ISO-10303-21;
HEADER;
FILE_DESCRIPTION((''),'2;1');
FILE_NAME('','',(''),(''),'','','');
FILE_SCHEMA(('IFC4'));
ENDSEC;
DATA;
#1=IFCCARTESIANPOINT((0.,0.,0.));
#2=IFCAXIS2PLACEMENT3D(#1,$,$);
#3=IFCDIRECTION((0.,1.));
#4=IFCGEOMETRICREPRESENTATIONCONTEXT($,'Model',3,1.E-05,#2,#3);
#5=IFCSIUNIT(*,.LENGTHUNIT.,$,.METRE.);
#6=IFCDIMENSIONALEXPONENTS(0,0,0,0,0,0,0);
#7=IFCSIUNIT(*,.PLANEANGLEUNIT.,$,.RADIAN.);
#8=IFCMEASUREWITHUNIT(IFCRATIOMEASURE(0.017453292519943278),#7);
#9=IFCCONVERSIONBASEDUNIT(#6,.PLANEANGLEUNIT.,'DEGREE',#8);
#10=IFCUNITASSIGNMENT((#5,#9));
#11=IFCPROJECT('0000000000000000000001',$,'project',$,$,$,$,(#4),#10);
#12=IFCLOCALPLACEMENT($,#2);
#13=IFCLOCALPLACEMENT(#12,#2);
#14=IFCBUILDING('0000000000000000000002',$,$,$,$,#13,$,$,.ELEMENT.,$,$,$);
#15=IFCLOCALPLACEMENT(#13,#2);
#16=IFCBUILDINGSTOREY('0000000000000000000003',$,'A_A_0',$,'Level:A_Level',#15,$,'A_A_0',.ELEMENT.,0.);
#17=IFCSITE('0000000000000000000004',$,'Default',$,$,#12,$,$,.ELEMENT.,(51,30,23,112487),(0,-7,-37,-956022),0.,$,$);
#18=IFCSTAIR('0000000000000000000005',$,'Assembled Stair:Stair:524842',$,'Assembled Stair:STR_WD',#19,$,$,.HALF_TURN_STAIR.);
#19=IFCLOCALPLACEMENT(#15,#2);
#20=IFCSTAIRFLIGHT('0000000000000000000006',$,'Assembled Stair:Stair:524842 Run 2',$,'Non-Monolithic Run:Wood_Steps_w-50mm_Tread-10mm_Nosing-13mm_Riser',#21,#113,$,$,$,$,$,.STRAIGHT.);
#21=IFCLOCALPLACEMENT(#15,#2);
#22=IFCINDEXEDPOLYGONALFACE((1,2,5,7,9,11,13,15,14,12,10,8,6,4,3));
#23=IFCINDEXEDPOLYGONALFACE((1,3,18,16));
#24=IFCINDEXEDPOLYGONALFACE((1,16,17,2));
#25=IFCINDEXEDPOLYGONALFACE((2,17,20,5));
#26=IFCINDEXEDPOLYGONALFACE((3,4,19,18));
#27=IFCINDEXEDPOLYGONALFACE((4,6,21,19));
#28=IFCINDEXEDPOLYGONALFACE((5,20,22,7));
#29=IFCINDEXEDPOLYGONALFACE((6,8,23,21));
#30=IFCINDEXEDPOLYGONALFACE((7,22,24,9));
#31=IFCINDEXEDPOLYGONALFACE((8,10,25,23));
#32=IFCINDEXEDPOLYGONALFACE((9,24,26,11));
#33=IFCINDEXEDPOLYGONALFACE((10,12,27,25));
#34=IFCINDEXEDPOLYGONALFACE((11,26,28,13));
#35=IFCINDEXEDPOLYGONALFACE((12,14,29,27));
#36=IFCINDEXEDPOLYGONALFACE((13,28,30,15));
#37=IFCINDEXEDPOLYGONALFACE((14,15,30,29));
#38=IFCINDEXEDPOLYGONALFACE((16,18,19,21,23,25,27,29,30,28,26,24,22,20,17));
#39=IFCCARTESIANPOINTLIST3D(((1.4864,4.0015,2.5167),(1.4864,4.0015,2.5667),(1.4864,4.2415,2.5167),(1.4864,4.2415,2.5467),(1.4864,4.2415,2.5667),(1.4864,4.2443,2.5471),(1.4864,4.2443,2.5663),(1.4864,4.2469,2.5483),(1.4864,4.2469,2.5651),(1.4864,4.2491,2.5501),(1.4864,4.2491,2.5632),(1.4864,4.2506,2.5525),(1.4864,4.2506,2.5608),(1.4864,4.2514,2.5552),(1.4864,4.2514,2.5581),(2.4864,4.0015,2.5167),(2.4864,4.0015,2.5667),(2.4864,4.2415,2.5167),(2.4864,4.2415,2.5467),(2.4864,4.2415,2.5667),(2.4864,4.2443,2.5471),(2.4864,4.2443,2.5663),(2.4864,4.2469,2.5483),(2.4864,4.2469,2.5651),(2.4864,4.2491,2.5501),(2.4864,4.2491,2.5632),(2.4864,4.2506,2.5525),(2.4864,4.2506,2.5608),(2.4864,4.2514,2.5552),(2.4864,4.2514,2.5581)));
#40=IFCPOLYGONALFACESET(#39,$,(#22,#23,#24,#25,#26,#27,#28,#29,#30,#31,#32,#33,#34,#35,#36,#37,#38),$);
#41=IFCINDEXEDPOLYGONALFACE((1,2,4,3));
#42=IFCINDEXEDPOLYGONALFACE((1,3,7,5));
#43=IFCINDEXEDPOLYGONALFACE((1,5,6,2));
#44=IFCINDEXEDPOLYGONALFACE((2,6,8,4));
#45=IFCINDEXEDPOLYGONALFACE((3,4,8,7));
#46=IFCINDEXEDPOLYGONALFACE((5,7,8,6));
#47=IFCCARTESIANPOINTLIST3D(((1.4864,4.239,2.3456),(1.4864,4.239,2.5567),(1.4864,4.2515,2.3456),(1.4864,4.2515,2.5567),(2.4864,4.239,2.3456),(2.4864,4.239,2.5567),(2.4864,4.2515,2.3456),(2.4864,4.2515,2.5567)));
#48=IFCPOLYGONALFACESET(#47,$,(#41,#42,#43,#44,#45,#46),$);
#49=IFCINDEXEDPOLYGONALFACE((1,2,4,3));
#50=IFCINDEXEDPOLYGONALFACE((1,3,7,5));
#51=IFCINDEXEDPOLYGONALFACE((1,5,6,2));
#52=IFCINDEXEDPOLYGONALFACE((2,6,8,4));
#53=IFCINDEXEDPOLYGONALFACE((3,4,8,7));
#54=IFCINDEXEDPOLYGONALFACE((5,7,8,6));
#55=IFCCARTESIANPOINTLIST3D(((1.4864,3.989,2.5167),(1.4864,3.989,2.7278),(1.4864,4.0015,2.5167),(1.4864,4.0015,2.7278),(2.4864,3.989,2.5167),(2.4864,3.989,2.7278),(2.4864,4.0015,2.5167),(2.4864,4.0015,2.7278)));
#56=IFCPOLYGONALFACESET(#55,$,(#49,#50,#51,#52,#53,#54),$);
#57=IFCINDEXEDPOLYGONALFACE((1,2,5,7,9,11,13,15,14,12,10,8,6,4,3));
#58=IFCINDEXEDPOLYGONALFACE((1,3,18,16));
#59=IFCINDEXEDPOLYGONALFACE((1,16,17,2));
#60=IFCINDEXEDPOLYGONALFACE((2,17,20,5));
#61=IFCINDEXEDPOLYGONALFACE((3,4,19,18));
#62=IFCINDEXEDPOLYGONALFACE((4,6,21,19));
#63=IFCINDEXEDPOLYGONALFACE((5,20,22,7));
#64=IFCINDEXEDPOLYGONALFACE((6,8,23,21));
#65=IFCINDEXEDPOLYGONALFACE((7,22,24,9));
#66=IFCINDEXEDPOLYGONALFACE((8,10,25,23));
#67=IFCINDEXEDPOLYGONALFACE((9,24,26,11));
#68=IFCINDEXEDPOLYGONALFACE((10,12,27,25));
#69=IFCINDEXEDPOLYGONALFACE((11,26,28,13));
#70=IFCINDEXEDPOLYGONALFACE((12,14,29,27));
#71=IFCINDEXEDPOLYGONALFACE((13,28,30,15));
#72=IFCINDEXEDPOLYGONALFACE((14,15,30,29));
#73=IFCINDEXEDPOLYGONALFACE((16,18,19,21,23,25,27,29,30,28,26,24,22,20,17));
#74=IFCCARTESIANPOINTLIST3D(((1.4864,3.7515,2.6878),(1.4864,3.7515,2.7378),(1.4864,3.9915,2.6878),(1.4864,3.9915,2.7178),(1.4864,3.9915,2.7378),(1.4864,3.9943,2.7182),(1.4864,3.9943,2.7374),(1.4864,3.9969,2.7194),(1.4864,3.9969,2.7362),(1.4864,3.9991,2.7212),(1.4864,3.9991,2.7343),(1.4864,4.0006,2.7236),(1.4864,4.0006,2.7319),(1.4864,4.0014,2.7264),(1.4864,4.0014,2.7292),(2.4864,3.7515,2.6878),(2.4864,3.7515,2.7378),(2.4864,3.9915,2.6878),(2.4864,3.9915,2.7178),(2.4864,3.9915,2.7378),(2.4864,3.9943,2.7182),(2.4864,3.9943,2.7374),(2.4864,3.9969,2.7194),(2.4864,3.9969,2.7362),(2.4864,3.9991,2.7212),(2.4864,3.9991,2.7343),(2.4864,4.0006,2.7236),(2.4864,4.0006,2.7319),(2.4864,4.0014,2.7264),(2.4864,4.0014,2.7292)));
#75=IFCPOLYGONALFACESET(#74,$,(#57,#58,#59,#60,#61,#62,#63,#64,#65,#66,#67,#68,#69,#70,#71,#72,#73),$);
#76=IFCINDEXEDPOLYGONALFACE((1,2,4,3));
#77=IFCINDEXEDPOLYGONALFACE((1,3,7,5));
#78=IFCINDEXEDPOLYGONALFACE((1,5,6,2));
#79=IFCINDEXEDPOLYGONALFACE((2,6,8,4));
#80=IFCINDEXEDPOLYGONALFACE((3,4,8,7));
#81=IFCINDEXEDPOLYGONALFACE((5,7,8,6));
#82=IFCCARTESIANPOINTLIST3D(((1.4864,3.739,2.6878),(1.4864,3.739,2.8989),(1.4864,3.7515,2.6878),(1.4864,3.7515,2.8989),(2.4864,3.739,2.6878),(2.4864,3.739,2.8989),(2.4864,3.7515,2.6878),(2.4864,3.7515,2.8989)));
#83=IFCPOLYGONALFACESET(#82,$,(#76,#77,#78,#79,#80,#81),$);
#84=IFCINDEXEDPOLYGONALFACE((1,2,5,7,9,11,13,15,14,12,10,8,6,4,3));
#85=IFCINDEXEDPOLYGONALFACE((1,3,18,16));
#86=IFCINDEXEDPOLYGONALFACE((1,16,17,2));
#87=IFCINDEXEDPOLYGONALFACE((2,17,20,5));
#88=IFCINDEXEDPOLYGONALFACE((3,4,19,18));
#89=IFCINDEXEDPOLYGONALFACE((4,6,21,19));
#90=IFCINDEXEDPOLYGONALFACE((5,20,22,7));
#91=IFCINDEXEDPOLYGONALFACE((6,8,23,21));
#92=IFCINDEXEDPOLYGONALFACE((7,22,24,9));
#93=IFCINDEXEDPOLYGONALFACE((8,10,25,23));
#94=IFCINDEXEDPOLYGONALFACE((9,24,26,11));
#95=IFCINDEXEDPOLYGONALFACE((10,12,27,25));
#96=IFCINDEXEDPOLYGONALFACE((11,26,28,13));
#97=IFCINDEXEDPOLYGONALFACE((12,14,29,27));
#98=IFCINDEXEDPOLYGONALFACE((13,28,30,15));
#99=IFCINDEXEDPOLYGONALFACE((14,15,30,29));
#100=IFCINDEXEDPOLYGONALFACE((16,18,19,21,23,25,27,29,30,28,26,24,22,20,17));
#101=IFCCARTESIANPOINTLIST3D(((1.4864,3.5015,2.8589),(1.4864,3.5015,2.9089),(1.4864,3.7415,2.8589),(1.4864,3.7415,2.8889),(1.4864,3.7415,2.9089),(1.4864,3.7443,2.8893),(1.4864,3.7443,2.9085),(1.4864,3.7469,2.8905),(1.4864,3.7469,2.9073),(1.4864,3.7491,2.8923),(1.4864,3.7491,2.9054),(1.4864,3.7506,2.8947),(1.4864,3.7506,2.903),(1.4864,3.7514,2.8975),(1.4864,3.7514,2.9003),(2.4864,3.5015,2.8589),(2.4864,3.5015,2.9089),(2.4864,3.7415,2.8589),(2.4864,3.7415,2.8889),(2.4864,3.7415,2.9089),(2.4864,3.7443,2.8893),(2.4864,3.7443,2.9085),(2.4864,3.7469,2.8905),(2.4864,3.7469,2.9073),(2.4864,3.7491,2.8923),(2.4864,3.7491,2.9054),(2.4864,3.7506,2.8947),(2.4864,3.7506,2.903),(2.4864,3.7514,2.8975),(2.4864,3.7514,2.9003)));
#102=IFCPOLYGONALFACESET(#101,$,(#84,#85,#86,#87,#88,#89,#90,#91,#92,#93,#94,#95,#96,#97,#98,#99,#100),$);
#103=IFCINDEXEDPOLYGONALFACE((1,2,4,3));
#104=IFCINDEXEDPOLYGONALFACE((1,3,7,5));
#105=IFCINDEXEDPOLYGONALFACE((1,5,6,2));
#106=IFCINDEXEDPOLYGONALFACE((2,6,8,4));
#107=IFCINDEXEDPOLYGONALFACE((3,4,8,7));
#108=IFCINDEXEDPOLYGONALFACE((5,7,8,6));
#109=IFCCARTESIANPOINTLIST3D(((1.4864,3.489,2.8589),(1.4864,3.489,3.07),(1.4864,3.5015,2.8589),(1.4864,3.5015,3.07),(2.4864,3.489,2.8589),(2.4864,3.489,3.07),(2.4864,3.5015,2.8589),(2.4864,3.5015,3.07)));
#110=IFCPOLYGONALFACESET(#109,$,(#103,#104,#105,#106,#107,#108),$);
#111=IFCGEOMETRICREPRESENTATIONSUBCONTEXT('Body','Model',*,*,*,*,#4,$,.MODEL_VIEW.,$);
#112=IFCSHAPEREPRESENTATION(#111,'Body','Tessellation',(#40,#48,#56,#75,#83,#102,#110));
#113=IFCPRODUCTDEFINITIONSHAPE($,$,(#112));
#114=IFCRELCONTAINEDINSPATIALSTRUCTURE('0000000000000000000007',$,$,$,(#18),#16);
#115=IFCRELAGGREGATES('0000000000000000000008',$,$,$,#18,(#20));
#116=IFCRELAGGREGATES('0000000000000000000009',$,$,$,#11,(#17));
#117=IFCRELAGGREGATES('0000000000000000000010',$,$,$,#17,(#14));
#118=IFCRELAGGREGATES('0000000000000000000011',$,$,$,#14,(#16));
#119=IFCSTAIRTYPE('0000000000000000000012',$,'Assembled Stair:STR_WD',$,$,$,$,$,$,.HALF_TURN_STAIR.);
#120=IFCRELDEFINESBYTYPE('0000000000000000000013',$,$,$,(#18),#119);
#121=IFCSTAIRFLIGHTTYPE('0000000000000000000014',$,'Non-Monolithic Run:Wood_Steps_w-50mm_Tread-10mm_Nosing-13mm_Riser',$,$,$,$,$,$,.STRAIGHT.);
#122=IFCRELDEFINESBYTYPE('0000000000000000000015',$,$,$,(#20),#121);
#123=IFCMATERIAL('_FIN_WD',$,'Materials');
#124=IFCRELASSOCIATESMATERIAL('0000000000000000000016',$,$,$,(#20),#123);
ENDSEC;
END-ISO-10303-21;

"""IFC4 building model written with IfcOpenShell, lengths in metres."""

from ifc_helpers import new_model, entity, si_unit, converted_unit, direction, frame, origin, place, context, subcontext, project, spatial, line, arc, indexed_curve, outline, extrude, material, type_object, element, aggregate, save


model = new_model("IFC4")

# Units and contexts
model_context = context("Model", 3, precision=1e-05, world=origin(), true_north=direction((0.0, 1.0)))
body_context = subcontext(model_context, "Body", "Model", "MODEL_VIEW")
ifc_project = project(units=[si_unit("LENGTHUNIT", "METRE"), converted_unit("PLANEANGLEUNIT", "DEGREE", entity("IfcRatioMeasure", 0.017453292519943278), si_unit("PLANEANGLEUNIT", "RADIAN"), dimensions=[0, 0, 0, 0, 0, 0, 0])], contexts=[model_context])

# Site, building, storey
site_placement = place(None, origin())
site = spatial("IfcSite", under=ifc_project, at=site_placement, Name="Default", CompositionType="ELEMENT", RefLatitude=(51, 30, 23, 112487), RefLongitude=(0, -7, -37, -956022), RefElevation=0.0)
building_placement = place(site_placement, origin())
building = spatial("IfcBuilding", under=site, at=building_placement, CompositionType="ELEMENT")
storey_placement = place(building_placement, origin())
storey = spatial("IfcBuildingStorey", under=building, at=storey_placement, Name="A_A_0", ObjectType="Level:A_Level", LongName="A_A_0", CompositionType="ELEMENT", Elevation=0.0)

# Stair, stair flight
stair_type = type_object("IfcStairType", Name="Assembled Stair:STR_WD", PredefinedType="HALF_TURN_STAIR")
stair_placement = place(storey_placement, origin())
stair = element("IfcStair", 1, at=stair_placement, inside=storey, type_object=stair_type, Name="Assembled Stair:Stair:524842", ObjectType="Assembled Stair:STR_WD", PredefinedType="HALF_TURN_STAIR")
ifc_material_1 = material(Name="_FIN_WD", Category="Materials")
stair_flight_type_1 = type_object("IfcStairFlightType", Name="Non-Monolithic Run:Wood_Steps_w-50mm_Tread-10mm_Nosing-13mm_Riser", PredefinedType="STRAIGHT")
stair_flight_1_placement = place(stair_placement, origin())
stair_flight_1 = element("IfcStairFlight", 2, at=stair_flight_1_placement, type_object=stair_flight_type_1, material=ifc_material_1, Name="Assembled Stair:Stair:524842 Run 2", ObjectType="Non-Monolithic Run:Wood_Steps_w-50mm_Tread-10mm_Nosing-13mm_Riser", PredefinedType="STRAIGHT", context=body_context, shape_type="SweptSolid", body=[
    extrude(outline(indexed_curve([(-0.024, -0.144), (0.026, -0.144), (0.026, 0.096), (-0.004, 0.096), (-0.014, 0.106), (-0.024, 0.096)], segments=[line(1, 2, 3, 4), arc(4, 5, 6), line(6, 1)], self_intersect=False)), frame((1.4864, 4.1455, 2.5427), z_axis=(1.0, 0.0, 0.0), x_axis=(0.0, 0.0, -1.0)), (0.0, 0.0, 1.0), 1.0),
    extrude(outline(indexed_curve([(-0.5, -0.0063), (0.5, -0.0063), (0.5, 0.0062), (-0.5, 0.0062), (-0.5, -0.0063)], self_intersect=False)), frame((1.9864, 4.2453, 2.3456)), (0.0, 0.0, 1.0), 0.2111),
    extrude(outline(indexed_curve([(-0.5, -0.0062), (0.5, -0.0062), (0.5, 0.0063), (-0.5, 0.0063), (-0.5, -0.0062)], self_intersect=False)), frame((1.9864, 3.9953, 2.5167)), (0.0, 0.0, 1.0), 0.2111),
    extrude(outline(indexed_curve([(-0.024, -0.144), (0.026, -0.144), (0.026, 0.096), (-0.004, 0.096), (-0.014, 0.106), (-0.024, 0.096)], segments=[line(1, 2, 3, 4), arc(4, 5, 6), line(6, 1)], self_intersect=False)), frame((1.4864, 3.8955, 2.7138), z_axis=(1.0, 0.0, 0.0), x_axis=(0.0, 0.0, -1.0)), (0.0, 0.0, 1.0), 1.0),
    extrude(outline(indexed_curve([(-0.5, -0.0063), (0.5, -0.0063), (0.5, 0.0062), (-0.5, 0.0062), (-0.5, -0.0063)], self_intersect=False)), frame((1.9864, 3.7453, 2.6878)), (0.0, 0.0, 1.0), 0.2111),
    extrude(outline(indexed_curve([(-0.024, -0.144), (0.026, -0.144), (0.026, 0.096), (-0.004, 0.096), (-0.014, 0.106), (-0.024, 0.096)], segments=[line(1, 2, 3, 4), arc(4, 5, 6), line(6, 1)], self_intersect=False)), frame((1.4864, 3.6455, 2.8849), z_axis=(1.0, 0.0, 0.0), x_axis=(0.0, 0.0, -1.0)), (0.0, 0.0, 1.0), 1.0),
    extrude(outline(indexed_curve([(-0.5, -0.0062), (0.5, -0.0062), (0.5, 0.0063), (-0.5, 0.0063), (-0.5, -0.0062)], self_intersect=False)), frame((1.9864, 3.4953, 2.8589)), (0.0, 0.0, 1.0), 0.2111),
])
aggregate(stair, [stair_flight_1])

save(model, "model.ifc")
